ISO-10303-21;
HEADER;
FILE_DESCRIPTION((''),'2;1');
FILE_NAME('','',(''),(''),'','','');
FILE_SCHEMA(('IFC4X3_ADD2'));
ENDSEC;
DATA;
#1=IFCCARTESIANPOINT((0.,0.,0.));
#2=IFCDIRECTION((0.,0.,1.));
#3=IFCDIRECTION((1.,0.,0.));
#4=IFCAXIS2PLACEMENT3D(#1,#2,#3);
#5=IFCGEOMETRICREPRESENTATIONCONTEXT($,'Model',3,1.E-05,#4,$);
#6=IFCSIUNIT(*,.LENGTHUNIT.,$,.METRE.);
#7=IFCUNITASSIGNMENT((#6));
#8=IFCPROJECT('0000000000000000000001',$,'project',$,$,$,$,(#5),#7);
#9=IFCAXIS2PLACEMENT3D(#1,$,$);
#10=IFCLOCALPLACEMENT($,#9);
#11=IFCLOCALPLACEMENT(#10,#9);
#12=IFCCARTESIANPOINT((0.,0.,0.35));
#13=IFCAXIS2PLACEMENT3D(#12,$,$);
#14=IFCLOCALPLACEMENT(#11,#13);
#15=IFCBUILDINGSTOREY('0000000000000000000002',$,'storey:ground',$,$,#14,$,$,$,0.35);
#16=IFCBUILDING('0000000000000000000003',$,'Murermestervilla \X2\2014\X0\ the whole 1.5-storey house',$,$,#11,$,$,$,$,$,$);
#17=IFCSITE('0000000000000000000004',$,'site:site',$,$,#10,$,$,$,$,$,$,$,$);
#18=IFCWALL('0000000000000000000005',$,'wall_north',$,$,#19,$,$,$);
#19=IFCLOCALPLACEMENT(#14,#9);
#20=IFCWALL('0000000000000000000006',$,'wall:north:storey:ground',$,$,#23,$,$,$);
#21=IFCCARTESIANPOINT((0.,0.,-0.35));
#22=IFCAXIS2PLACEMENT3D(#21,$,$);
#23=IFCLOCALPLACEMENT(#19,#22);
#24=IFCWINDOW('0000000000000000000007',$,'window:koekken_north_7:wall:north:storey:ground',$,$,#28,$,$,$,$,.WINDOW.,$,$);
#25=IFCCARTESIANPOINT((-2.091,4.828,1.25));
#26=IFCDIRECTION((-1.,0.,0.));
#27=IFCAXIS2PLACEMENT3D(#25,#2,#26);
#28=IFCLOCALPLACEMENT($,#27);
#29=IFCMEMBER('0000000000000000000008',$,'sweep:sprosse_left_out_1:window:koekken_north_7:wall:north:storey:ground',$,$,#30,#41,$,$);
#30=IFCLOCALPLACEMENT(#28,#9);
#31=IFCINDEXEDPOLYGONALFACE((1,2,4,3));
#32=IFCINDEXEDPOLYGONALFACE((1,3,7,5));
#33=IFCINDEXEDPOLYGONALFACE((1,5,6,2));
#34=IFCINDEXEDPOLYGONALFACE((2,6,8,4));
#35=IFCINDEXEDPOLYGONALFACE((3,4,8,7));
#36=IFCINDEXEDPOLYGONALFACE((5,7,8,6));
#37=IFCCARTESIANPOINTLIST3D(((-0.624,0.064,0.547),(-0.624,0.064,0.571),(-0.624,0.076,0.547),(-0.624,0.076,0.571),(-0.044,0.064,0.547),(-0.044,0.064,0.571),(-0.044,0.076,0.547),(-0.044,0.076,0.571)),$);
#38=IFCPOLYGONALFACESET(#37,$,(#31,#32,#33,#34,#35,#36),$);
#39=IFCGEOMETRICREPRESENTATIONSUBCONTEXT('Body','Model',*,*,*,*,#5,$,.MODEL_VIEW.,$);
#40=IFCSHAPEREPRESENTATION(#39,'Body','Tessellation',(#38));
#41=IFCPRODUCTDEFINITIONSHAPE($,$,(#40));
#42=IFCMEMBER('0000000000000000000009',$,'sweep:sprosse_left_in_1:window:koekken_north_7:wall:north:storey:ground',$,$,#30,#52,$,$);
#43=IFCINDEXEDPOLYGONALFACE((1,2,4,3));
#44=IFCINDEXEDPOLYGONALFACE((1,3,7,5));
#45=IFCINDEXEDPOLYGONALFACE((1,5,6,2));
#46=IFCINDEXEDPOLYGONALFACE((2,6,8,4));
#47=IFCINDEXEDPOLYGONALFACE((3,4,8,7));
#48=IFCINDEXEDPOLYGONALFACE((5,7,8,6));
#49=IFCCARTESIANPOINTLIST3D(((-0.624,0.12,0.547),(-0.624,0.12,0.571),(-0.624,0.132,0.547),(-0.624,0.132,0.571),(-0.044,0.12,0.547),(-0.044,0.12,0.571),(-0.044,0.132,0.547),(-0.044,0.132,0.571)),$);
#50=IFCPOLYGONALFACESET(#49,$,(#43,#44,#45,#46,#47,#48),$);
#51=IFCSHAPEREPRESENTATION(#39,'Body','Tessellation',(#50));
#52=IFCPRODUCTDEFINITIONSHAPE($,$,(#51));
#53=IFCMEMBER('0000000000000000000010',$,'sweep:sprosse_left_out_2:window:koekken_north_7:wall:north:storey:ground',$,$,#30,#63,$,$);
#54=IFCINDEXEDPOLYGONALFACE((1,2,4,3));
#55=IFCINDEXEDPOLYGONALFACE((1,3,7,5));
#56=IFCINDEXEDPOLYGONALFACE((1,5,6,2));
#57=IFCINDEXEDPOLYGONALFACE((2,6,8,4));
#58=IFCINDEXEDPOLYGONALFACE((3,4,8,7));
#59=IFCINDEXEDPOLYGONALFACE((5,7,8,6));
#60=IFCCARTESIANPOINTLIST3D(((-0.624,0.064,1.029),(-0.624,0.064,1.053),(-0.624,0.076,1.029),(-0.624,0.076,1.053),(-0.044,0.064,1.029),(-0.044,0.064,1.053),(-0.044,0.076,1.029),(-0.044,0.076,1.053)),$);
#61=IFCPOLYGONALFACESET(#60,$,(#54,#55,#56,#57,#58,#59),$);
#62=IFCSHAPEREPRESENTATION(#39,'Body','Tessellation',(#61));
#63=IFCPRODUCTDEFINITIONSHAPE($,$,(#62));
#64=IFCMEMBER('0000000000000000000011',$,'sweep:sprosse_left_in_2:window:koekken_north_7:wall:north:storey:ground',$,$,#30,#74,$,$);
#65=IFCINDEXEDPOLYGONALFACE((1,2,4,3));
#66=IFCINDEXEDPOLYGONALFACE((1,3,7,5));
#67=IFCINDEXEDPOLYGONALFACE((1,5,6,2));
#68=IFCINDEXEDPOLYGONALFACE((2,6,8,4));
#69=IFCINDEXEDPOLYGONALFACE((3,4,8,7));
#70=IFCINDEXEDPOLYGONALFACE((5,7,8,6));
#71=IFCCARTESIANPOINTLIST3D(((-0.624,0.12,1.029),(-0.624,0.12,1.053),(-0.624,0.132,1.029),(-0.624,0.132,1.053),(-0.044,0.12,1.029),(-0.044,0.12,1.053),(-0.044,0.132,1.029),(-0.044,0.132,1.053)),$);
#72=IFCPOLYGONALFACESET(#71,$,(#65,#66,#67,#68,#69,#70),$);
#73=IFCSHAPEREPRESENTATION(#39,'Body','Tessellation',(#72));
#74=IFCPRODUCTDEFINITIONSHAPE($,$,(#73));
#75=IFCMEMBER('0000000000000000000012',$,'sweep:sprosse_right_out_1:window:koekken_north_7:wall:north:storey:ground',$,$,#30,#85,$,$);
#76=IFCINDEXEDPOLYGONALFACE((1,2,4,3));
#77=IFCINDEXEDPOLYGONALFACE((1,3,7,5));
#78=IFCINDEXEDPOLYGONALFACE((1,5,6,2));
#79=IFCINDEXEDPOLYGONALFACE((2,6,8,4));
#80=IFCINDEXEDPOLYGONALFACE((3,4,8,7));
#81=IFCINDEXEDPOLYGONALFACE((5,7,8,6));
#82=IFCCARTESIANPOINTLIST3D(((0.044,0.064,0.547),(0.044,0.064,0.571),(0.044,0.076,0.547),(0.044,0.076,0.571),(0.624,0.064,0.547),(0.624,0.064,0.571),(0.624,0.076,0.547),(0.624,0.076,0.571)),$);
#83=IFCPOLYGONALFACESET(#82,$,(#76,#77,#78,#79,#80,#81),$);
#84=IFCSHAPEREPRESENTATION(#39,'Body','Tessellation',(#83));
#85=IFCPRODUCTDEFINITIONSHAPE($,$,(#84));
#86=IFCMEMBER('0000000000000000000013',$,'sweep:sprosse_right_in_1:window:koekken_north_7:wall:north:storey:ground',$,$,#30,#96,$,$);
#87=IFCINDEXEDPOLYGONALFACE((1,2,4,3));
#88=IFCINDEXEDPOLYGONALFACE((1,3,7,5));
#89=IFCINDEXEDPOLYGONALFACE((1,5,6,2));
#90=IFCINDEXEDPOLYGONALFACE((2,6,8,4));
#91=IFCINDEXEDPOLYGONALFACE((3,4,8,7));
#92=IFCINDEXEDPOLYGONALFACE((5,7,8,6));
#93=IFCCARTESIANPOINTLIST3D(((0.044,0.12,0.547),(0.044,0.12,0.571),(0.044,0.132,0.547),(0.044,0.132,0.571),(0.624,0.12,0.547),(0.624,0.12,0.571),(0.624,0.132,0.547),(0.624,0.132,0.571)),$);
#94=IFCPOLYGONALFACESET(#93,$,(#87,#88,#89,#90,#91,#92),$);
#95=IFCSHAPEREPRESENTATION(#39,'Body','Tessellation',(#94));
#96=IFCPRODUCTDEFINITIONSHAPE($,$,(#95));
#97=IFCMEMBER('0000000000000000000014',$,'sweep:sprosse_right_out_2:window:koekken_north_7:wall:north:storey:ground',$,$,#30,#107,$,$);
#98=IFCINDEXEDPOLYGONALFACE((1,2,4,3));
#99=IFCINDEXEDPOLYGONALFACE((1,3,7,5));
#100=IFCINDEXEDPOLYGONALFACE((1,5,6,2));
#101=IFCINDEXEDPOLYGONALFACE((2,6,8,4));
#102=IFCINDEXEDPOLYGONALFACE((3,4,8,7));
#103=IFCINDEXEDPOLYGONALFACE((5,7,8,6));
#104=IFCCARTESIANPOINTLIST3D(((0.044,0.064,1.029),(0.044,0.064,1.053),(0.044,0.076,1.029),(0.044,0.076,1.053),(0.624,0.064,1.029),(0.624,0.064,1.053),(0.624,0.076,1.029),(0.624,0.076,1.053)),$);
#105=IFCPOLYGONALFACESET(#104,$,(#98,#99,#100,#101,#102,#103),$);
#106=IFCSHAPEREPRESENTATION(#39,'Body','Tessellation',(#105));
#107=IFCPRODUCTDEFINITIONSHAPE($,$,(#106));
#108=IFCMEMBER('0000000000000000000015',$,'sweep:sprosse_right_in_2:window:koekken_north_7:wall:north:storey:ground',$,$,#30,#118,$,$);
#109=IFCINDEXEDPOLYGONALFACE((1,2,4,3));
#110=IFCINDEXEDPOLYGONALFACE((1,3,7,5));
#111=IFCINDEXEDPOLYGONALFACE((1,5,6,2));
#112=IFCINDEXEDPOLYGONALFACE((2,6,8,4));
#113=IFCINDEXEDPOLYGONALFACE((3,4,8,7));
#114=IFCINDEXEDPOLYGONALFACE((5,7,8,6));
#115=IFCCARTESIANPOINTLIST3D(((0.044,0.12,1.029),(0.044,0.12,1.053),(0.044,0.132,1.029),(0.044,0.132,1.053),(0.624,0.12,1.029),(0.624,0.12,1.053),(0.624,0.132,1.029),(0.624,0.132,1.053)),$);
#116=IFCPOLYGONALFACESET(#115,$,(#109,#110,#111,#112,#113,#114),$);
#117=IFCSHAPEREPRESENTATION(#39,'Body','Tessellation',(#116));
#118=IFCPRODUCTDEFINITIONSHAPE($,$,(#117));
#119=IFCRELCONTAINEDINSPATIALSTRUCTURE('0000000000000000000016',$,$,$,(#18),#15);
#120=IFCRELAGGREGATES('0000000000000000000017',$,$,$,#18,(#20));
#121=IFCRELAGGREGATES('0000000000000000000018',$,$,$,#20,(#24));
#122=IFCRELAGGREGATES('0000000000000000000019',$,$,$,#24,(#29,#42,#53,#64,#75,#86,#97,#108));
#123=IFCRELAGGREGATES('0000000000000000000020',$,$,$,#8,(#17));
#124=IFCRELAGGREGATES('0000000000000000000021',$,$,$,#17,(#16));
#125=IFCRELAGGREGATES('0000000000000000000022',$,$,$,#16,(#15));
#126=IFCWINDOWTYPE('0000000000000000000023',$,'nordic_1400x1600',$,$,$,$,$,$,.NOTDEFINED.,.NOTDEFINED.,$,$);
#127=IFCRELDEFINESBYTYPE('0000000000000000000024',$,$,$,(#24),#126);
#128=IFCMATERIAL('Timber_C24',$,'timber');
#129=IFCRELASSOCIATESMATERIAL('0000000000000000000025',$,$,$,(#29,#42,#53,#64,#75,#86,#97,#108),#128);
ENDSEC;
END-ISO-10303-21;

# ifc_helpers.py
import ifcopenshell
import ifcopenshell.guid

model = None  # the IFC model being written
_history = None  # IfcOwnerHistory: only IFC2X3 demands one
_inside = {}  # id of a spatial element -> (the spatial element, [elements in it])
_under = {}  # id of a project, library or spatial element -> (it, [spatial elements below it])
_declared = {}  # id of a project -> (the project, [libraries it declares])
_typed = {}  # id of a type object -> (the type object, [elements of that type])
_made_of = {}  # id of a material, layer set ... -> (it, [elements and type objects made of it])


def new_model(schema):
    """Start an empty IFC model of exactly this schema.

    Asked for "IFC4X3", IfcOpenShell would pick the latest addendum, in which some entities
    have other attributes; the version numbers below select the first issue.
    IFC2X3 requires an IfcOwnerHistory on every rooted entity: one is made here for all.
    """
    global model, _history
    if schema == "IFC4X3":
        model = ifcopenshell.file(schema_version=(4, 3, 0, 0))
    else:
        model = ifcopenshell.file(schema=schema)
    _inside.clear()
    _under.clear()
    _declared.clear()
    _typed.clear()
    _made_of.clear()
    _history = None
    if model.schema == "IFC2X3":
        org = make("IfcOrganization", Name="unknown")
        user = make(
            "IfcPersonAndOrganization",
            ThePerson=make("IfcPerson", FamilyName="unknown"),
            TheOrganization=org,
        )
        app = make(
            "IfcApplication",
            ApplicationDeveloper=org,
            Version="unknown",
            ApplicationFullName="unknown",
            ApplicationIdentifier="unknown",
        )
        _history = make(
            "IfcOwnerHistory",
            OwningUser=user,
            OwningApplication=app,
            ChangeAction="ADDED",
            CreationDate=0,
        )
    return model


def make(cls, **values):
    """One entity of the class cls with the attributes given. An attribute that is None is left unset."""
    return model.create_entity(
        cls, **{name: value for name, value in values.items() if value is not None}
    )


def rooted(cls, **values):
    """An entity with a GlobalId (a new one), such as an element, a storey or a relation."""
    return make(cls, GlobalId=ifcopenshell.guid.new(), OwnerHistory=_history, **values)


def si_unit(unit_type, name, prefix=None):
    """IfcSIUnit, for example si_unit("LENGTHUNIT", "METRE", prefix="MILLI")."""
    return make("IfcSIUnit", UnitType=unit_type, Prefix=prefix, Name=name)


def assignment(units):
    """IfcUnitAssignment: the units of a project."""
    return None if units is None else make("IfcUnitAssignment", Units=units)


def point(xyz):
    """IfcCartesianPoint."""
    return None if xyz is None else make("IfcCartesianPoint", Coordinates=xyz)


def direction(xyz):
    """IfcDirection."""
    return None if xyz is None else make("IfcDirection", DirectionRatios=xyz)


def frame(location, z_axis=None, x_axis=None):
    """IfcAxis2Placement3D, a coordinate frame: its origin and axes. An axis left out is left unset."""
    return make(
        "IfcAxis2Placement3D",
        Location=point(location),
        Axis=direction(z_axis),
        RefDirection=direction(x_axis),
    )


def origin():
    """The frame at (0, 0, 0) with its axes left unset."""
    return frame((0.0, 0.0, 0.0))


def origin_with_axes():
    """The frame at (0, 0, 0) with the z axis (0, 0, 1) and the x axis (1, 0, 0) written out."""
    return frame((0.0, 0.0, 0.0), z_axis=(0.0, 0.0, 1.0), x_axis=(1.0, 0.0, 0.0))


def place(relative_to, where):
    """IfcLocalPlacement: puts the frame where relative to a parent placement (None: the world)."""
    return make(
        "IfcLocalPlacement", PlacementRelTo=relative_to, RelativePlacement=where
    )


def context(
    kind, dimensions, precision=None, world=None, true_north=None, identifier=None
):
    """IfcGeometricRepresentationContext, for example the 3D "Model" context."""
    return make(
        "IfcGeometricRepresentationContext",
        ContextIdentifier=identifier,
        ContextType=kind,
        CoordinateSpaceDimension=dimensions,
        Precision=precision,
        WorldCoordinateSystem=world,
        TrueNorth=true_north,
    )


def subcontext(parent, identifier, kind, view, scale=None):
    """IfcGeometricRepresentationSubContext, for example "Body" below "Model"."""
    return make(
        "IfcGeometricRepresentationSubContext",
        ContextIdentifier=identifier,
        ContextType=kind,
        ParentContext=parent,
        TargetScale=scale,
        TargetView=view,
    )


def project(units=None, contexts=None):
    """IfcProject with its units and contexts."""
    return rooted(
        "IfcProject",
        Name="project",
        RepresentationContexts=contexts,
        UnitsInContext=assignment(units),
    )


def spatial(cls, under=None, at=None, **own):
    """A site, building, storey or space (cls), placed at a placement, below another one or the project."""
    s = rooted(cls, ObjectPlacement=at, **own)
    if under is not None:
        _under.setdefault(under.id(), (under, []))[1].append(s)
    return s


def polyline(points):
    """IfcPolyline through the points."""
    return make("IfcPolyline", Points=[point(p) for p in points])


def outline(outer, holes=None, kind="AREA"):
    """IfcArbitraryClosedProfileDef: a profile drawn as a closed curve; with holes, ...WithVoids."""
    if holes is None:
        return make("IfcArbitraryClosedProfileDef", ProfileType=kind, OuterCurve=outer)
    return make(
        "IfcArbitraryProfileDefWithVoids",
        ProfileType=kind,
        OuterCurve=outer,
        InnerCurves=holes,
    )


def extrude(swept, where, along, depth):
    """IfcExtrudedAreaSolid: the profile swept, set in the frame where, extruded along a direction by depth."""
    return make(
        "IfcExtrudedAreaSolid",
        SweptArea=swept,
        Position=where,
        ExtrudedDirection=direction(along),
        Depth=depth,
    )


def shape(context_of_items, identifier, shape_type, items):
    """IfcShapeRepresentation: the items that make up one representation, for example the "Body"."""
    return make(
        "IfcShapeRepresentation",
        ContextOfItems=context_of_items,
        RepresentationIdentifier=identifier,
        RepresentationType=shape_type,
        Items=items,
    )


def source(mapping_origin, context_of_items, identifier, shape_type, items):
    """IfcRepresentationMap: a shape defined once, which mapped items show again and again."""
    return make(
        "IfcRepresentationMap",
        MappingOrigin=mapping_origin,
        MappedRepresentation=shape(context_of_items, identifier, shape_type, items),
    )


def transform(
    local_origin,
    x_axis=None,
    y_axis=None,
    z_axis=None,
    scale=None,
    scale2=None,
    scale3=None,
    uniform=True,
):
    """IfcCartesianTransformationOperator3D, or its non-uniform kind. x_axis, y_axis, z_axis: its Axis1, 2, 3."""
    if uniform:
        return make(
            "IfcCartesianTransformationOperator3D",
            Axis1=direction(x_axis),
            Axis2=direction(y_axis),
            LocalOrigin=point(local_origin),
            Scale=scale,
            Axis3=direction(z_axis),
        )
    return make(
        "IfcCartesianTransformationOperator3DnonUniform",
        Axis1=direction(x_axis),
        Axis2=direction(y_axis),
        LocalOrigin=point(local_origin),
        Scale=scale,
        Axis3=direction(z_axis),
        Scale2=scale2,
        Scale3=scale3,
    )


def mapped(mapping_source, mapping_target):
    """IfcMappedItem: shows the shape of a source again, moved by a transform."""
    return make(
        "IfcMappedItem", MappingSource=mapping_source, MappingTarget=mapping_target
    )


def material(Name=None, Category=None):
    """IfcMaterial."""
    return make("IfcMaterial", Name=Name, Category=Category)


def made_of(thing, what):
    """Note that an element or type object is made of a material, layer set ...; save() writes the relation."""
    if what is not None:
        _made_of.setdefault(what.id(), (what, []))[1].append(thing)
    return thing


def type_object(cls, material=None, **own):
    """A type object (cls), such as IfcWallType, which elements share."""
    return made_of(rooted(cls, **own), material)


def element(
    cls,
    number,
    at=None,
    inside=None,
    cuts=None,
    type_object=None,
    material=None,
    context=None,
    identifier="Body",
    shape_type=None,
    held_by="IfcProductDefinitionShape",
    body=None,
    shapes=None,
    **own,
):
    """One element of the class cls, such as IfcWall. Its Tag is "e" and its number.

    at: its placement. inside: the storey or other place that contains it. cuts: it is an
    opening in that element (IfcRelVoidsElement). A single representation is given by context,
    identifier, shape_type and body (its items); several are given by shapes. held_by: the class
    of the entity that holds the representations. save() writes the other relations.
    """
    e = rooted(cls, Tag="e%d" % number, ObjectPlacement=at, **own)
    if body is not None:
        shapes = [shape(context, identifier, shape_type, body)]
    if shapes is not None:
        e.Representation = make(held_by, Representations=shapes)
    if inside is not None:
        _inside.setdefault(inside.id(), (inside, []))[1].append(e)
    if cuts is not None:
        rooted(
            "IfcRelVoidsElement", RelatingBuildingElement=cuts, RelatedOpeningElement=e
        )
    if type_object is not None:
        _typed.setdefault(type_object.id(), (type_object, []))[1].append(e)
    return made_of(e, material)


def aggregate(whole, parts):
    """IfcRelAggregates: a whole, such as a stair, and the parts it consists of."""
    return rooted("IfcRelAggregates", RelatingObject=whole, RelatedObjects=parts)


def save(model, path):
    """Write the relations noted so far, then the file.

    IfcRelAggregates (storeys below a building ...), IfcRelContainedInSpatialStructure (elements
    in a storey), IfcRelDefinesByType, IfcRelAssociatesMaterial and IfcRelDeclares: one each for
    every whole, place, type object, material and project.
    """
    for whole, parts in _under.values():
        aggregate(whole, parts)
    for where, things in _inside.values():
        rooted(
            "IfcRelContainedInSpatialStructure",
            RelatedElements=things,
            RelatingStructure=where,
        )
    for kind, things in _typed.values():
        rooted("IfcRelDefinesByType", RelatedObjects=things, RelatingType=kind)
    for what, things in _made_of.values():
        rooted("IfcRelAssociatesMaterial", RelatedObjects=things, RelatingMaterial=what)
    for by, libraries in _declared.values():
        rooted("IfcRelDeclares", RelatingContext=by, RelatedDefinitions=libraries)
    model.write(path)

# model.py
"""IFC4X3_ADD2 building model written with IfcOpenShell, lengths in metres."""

from ifc_helpers import new_model, si_unit, frame, origin, origin_with_axes, place, context, subcontext, project, spatial, polyline, outline, extrude, source, transform, mapped, material, type_object, element, aggregate, save


model = new_model("IFC4X3_ADD2")

# Units and contexts
model_context = context("Model", 3, precision=1e-05, world=origin_with_axes())
body_context = subcontext(model_context, "Body", "Model", "MODEL_VIEW")
ifc_project = project(units=[si_unit("LENGTHUNIT", "METRE")], contexts=[model_context])

# Site, building, storey
site_placement = place(None, origin())
site = spatial("IfcSite", under=ifc_project, at=site_placement, Name="site:site")
building_placement = place(site_placement, origin())
building = spatial("IfcBuilding", under=site, at=building_placement, Name="Murermestervilla — the whole 1.5-storey house")
storey_placement = place(building_placement, frame((0.0, 0.0, 0.35)))
storey = spatial("IfcBuildingStorey", under=building, at=storey_placement, Name="storey:ground", Elevation=0.35)

# Walls, window, members
wall_1_placement = place(storey_placement, origin())
wall_1 = element("IfcWall", 1, at=wall_1_placement, inside=storey, Name="wall_north")
wall_2_placement = place(wall_1_placement, frame((0.0, 0.0, -0.35)))
wall_2 = element("IfcWall", 2, at=wall_2_placement, Name="wall:north:storey:ground")
aggregate(wall_1, [wall_2])
window_type = type_object("IfcWindowType", Name="nordic_1400x1600", PartitioningType="NOTDEFINED", PredefinedType="NOTDEFINED")
window_placement = place(None, frame((-2.091, 4.828, 1.25), z_axis=(0.0, 0.0, 1.0), x_axis=(-1.0, 0.0, 0.0)))
window = element("IfcWindow", 3, at=window_placement, type_object=window_type, Name="window:koekken_north_7:wall:north:storey:ground", PredefinedType="WINDOW")
aggregate(wall_2, [window])
ifc_material_1 = material(Name="Timber_C24", Category="timber")
placement = place(window_placement, origin())
shared_shape_1 = source(origin(), body_context, "Body", "SweptSolid", [
    extrude(outline(polyline([(-0.006, -0.012), (0.006, -0.012), (0.006, 0.012), (-0.006, 0.012), (-0.006, -0.012)])), frame((-0.624, 0.07, 0.559), z_axis=(1.0, 0.0, 0.0), x_axis=(0.0, 1.0, 0.0)), (0.0, 0.0, 1.0), 0.58),
])
member_1 = element("IfcMember", 4, at=placement, material=ifc_material_1, Name="sweep:sprosse_left_out_1:window:koekken_north_7:wall:north:storey:ground", context=body_context, shape_type="MappedRepresentation", body=[
    mapped(shared_shape_1, transform((0.0, 0.0, 0.0))),
])
shared_shape_2 = source(origin(), body_context, "Body", "SweptSolid", [
    extrude(outline(polyline([(-0.006, -0.012), (0.006, -0.012), (0.006, 0.012), (-0.006, 0.012), (-0.006, -0.012)])), frame((-0.624, 0.126, 0.559), z_axis=(1.0, 0.0, 0.0), x_axis=(0.0, 1.0, 0.0)), (0.0, 0.0, 1.0), 0.58),
])
member_2 = element("IfcMember", 5, at=placement, material=ifc_material_1, Name="sweep:sprosse_left_in_1:window:koekken_north_7:wall:north:storey:ground", context=body_context, shape_type="MappedRepresentation", body=[
    mapped(shared_shape_2, transform((0.0, 0.0, 0.0))),
])
shared_shape_3 = source(origin(), body_context, "Body", "SweptSolid", [
    extrude(outline(polyline([(-0.006, -0.012), (0.006, -0.012), (0.006, 0.012), (-0.006, 0.012), (-0.006, -0.012)])), frame((-0.624, 0.07, 1.041), z_axis=(1.0, 0.0, 0.0), x_axis=(0.0, 1.0, 0.0)), (0.0, 0.0, 1.0), 0.58),
])
member_3 = element("IfcMember", 6, at=placement, material=ifc_material_1, Name="sweep:sprosse_left_out_2:window:koekken_north_7:wall:north:storey:ground", context=body_context, shape_type="MappedRepresentation", body=[
    mapped(shared_shape_3, transform((0.0, 0.0, 0.0))),
])
shared_shape_4 = source(origin(), body_context, "Body", "SweptSolid", [
    extrude(outline(polyline([(-0.006, -0.012), (0.006, -0.012), (0.006, 0.012), (-0.006, 0.012), (-0.006, -0.012)])), frame((-0.624, 0.126, 1.041), z_axis=(1.0, 0.0, 0.0), x_axis=(0.0, 1.0, 0.0)), (0.0, 0.0, 1.0), 0.58),
])
member_4 = element("IfcMember", 7, at=placement, material=ifc_material_1, Name="sweep:sprosse_left_in_2:window:koekken_north_7:wall:north:storey:ground", context=body_context, shape_type="MappedRepresentation", body=[
    mapped(shared_shape_4, transform((0.0, 0.0, 0.0))),
])
shared_shape_5 = source(origin(), body_context, "Body", "SweptSolid", [
    extrude(outline(polyline([(-0.006, -0.012), (0.006, -0.012), (0.006, 0.012), (-0.006, 0.012), (-0.006, -0.012)])), frame((0.044, 0.07, 0.559), z_axis=(1.0, 0.0, 0.0), x_axis=(0.0, 1.0, 0.0)), (0.0, 0.0, 1.0), 0.58),
])
member_5 = element("IfcMember", 8, at=placement, material=ifc_material_1, Name="sweep:sprosse_right_out_1:window:koekken_north_7:wall:north:storey:ground", context=body_context, shape_type="MappedRepresentation", body=[
    mapped(shared_shape_5, transform((0.0, 0.0, 0.0))),
])
shared_shape_6 = source(origin(), body_context, "Body", "SweptSolid", [
    extrude(outline(polyline([(-0.006, -0.012), (0.006, -0.012), (0.006, 0.012), (-0.006, 0.012), (-0.006, -0.012)])), frame((0.044, 0.126, 0.559), z_axis=(1.0, 0.0, 0.0), x_axis=(0.0, 1.0, 0.0)), (0.0, 0.0, 1.0), 0.58),
])
member_6 = element("IfcMember", 9, at=placement, material=ifc_material_1, Name="sweep:sprosse_right_in_1:window:koekken_north_7:wall:north:storey:ground", context=body_context, shape_type="MappedRepresentation", body=[
    mapped(shared_shape_6, transform((0.0, 0.0, 0.0))),
])
shared_shape_7 = source(origin(), body_context, "Body", "SweptSolid", [
    extrude(outline(polyline([(-0.006, -0.012), (0.006, -0.012), (0.006, 0.012), (-0.006, 0.012), (-0.006, -0.012)])), frame((0.044, 0.07, 1.041), z_axis=(1.0, 0.0, 0.0), x_axis=(0.0, 1.0, 0.0)), (0.0, 0.0, 1.0), 0.58),
])
member_7 = element("IfcMember", 10, at=placement, material=ifc_material_1, Name="sweep:sprosse_right_out_2:window:koekken_north_7:wall:north:storey:ground", context=body_context, shape_type="MappedRepresentation", body=[
    mapped(shared_shape_7, transform((0.0, 0.0, 0.0))),
])
shared_shape_8 = source(origin(), body_context, "Body", "SweptSolid", [
    extrude(outline(polyline([(-0.006, -0.012), (0.006, -0.012), (0.006, 0.012), (-0.006, 0.012), (-0.006, -0.012)])), frame((0.044, 0.126, 1.041), z_axis=(1.0, 0.0, 0.0), x_axis=(0.0, 1.0, 0.0)), (0.0, 0.0, 1.0), 0.58),
])
member_8 = element("IfcMember", 11, at=placement, material=ifc_material_1, Name="sweep:sprosse_right_in_2:window:koekken_north_7:wall:north:storey:ground", context=body_context, shape_type="MappedRepresentation", body=[
    mapped(shared_shape_8, transform((0.0, 0.0, 0.0))),
])

aggregate(window, [member_1, member_2, member_3, member_4, member_5, member_6, member_7, member_8])

save(model, "model.ifc")
